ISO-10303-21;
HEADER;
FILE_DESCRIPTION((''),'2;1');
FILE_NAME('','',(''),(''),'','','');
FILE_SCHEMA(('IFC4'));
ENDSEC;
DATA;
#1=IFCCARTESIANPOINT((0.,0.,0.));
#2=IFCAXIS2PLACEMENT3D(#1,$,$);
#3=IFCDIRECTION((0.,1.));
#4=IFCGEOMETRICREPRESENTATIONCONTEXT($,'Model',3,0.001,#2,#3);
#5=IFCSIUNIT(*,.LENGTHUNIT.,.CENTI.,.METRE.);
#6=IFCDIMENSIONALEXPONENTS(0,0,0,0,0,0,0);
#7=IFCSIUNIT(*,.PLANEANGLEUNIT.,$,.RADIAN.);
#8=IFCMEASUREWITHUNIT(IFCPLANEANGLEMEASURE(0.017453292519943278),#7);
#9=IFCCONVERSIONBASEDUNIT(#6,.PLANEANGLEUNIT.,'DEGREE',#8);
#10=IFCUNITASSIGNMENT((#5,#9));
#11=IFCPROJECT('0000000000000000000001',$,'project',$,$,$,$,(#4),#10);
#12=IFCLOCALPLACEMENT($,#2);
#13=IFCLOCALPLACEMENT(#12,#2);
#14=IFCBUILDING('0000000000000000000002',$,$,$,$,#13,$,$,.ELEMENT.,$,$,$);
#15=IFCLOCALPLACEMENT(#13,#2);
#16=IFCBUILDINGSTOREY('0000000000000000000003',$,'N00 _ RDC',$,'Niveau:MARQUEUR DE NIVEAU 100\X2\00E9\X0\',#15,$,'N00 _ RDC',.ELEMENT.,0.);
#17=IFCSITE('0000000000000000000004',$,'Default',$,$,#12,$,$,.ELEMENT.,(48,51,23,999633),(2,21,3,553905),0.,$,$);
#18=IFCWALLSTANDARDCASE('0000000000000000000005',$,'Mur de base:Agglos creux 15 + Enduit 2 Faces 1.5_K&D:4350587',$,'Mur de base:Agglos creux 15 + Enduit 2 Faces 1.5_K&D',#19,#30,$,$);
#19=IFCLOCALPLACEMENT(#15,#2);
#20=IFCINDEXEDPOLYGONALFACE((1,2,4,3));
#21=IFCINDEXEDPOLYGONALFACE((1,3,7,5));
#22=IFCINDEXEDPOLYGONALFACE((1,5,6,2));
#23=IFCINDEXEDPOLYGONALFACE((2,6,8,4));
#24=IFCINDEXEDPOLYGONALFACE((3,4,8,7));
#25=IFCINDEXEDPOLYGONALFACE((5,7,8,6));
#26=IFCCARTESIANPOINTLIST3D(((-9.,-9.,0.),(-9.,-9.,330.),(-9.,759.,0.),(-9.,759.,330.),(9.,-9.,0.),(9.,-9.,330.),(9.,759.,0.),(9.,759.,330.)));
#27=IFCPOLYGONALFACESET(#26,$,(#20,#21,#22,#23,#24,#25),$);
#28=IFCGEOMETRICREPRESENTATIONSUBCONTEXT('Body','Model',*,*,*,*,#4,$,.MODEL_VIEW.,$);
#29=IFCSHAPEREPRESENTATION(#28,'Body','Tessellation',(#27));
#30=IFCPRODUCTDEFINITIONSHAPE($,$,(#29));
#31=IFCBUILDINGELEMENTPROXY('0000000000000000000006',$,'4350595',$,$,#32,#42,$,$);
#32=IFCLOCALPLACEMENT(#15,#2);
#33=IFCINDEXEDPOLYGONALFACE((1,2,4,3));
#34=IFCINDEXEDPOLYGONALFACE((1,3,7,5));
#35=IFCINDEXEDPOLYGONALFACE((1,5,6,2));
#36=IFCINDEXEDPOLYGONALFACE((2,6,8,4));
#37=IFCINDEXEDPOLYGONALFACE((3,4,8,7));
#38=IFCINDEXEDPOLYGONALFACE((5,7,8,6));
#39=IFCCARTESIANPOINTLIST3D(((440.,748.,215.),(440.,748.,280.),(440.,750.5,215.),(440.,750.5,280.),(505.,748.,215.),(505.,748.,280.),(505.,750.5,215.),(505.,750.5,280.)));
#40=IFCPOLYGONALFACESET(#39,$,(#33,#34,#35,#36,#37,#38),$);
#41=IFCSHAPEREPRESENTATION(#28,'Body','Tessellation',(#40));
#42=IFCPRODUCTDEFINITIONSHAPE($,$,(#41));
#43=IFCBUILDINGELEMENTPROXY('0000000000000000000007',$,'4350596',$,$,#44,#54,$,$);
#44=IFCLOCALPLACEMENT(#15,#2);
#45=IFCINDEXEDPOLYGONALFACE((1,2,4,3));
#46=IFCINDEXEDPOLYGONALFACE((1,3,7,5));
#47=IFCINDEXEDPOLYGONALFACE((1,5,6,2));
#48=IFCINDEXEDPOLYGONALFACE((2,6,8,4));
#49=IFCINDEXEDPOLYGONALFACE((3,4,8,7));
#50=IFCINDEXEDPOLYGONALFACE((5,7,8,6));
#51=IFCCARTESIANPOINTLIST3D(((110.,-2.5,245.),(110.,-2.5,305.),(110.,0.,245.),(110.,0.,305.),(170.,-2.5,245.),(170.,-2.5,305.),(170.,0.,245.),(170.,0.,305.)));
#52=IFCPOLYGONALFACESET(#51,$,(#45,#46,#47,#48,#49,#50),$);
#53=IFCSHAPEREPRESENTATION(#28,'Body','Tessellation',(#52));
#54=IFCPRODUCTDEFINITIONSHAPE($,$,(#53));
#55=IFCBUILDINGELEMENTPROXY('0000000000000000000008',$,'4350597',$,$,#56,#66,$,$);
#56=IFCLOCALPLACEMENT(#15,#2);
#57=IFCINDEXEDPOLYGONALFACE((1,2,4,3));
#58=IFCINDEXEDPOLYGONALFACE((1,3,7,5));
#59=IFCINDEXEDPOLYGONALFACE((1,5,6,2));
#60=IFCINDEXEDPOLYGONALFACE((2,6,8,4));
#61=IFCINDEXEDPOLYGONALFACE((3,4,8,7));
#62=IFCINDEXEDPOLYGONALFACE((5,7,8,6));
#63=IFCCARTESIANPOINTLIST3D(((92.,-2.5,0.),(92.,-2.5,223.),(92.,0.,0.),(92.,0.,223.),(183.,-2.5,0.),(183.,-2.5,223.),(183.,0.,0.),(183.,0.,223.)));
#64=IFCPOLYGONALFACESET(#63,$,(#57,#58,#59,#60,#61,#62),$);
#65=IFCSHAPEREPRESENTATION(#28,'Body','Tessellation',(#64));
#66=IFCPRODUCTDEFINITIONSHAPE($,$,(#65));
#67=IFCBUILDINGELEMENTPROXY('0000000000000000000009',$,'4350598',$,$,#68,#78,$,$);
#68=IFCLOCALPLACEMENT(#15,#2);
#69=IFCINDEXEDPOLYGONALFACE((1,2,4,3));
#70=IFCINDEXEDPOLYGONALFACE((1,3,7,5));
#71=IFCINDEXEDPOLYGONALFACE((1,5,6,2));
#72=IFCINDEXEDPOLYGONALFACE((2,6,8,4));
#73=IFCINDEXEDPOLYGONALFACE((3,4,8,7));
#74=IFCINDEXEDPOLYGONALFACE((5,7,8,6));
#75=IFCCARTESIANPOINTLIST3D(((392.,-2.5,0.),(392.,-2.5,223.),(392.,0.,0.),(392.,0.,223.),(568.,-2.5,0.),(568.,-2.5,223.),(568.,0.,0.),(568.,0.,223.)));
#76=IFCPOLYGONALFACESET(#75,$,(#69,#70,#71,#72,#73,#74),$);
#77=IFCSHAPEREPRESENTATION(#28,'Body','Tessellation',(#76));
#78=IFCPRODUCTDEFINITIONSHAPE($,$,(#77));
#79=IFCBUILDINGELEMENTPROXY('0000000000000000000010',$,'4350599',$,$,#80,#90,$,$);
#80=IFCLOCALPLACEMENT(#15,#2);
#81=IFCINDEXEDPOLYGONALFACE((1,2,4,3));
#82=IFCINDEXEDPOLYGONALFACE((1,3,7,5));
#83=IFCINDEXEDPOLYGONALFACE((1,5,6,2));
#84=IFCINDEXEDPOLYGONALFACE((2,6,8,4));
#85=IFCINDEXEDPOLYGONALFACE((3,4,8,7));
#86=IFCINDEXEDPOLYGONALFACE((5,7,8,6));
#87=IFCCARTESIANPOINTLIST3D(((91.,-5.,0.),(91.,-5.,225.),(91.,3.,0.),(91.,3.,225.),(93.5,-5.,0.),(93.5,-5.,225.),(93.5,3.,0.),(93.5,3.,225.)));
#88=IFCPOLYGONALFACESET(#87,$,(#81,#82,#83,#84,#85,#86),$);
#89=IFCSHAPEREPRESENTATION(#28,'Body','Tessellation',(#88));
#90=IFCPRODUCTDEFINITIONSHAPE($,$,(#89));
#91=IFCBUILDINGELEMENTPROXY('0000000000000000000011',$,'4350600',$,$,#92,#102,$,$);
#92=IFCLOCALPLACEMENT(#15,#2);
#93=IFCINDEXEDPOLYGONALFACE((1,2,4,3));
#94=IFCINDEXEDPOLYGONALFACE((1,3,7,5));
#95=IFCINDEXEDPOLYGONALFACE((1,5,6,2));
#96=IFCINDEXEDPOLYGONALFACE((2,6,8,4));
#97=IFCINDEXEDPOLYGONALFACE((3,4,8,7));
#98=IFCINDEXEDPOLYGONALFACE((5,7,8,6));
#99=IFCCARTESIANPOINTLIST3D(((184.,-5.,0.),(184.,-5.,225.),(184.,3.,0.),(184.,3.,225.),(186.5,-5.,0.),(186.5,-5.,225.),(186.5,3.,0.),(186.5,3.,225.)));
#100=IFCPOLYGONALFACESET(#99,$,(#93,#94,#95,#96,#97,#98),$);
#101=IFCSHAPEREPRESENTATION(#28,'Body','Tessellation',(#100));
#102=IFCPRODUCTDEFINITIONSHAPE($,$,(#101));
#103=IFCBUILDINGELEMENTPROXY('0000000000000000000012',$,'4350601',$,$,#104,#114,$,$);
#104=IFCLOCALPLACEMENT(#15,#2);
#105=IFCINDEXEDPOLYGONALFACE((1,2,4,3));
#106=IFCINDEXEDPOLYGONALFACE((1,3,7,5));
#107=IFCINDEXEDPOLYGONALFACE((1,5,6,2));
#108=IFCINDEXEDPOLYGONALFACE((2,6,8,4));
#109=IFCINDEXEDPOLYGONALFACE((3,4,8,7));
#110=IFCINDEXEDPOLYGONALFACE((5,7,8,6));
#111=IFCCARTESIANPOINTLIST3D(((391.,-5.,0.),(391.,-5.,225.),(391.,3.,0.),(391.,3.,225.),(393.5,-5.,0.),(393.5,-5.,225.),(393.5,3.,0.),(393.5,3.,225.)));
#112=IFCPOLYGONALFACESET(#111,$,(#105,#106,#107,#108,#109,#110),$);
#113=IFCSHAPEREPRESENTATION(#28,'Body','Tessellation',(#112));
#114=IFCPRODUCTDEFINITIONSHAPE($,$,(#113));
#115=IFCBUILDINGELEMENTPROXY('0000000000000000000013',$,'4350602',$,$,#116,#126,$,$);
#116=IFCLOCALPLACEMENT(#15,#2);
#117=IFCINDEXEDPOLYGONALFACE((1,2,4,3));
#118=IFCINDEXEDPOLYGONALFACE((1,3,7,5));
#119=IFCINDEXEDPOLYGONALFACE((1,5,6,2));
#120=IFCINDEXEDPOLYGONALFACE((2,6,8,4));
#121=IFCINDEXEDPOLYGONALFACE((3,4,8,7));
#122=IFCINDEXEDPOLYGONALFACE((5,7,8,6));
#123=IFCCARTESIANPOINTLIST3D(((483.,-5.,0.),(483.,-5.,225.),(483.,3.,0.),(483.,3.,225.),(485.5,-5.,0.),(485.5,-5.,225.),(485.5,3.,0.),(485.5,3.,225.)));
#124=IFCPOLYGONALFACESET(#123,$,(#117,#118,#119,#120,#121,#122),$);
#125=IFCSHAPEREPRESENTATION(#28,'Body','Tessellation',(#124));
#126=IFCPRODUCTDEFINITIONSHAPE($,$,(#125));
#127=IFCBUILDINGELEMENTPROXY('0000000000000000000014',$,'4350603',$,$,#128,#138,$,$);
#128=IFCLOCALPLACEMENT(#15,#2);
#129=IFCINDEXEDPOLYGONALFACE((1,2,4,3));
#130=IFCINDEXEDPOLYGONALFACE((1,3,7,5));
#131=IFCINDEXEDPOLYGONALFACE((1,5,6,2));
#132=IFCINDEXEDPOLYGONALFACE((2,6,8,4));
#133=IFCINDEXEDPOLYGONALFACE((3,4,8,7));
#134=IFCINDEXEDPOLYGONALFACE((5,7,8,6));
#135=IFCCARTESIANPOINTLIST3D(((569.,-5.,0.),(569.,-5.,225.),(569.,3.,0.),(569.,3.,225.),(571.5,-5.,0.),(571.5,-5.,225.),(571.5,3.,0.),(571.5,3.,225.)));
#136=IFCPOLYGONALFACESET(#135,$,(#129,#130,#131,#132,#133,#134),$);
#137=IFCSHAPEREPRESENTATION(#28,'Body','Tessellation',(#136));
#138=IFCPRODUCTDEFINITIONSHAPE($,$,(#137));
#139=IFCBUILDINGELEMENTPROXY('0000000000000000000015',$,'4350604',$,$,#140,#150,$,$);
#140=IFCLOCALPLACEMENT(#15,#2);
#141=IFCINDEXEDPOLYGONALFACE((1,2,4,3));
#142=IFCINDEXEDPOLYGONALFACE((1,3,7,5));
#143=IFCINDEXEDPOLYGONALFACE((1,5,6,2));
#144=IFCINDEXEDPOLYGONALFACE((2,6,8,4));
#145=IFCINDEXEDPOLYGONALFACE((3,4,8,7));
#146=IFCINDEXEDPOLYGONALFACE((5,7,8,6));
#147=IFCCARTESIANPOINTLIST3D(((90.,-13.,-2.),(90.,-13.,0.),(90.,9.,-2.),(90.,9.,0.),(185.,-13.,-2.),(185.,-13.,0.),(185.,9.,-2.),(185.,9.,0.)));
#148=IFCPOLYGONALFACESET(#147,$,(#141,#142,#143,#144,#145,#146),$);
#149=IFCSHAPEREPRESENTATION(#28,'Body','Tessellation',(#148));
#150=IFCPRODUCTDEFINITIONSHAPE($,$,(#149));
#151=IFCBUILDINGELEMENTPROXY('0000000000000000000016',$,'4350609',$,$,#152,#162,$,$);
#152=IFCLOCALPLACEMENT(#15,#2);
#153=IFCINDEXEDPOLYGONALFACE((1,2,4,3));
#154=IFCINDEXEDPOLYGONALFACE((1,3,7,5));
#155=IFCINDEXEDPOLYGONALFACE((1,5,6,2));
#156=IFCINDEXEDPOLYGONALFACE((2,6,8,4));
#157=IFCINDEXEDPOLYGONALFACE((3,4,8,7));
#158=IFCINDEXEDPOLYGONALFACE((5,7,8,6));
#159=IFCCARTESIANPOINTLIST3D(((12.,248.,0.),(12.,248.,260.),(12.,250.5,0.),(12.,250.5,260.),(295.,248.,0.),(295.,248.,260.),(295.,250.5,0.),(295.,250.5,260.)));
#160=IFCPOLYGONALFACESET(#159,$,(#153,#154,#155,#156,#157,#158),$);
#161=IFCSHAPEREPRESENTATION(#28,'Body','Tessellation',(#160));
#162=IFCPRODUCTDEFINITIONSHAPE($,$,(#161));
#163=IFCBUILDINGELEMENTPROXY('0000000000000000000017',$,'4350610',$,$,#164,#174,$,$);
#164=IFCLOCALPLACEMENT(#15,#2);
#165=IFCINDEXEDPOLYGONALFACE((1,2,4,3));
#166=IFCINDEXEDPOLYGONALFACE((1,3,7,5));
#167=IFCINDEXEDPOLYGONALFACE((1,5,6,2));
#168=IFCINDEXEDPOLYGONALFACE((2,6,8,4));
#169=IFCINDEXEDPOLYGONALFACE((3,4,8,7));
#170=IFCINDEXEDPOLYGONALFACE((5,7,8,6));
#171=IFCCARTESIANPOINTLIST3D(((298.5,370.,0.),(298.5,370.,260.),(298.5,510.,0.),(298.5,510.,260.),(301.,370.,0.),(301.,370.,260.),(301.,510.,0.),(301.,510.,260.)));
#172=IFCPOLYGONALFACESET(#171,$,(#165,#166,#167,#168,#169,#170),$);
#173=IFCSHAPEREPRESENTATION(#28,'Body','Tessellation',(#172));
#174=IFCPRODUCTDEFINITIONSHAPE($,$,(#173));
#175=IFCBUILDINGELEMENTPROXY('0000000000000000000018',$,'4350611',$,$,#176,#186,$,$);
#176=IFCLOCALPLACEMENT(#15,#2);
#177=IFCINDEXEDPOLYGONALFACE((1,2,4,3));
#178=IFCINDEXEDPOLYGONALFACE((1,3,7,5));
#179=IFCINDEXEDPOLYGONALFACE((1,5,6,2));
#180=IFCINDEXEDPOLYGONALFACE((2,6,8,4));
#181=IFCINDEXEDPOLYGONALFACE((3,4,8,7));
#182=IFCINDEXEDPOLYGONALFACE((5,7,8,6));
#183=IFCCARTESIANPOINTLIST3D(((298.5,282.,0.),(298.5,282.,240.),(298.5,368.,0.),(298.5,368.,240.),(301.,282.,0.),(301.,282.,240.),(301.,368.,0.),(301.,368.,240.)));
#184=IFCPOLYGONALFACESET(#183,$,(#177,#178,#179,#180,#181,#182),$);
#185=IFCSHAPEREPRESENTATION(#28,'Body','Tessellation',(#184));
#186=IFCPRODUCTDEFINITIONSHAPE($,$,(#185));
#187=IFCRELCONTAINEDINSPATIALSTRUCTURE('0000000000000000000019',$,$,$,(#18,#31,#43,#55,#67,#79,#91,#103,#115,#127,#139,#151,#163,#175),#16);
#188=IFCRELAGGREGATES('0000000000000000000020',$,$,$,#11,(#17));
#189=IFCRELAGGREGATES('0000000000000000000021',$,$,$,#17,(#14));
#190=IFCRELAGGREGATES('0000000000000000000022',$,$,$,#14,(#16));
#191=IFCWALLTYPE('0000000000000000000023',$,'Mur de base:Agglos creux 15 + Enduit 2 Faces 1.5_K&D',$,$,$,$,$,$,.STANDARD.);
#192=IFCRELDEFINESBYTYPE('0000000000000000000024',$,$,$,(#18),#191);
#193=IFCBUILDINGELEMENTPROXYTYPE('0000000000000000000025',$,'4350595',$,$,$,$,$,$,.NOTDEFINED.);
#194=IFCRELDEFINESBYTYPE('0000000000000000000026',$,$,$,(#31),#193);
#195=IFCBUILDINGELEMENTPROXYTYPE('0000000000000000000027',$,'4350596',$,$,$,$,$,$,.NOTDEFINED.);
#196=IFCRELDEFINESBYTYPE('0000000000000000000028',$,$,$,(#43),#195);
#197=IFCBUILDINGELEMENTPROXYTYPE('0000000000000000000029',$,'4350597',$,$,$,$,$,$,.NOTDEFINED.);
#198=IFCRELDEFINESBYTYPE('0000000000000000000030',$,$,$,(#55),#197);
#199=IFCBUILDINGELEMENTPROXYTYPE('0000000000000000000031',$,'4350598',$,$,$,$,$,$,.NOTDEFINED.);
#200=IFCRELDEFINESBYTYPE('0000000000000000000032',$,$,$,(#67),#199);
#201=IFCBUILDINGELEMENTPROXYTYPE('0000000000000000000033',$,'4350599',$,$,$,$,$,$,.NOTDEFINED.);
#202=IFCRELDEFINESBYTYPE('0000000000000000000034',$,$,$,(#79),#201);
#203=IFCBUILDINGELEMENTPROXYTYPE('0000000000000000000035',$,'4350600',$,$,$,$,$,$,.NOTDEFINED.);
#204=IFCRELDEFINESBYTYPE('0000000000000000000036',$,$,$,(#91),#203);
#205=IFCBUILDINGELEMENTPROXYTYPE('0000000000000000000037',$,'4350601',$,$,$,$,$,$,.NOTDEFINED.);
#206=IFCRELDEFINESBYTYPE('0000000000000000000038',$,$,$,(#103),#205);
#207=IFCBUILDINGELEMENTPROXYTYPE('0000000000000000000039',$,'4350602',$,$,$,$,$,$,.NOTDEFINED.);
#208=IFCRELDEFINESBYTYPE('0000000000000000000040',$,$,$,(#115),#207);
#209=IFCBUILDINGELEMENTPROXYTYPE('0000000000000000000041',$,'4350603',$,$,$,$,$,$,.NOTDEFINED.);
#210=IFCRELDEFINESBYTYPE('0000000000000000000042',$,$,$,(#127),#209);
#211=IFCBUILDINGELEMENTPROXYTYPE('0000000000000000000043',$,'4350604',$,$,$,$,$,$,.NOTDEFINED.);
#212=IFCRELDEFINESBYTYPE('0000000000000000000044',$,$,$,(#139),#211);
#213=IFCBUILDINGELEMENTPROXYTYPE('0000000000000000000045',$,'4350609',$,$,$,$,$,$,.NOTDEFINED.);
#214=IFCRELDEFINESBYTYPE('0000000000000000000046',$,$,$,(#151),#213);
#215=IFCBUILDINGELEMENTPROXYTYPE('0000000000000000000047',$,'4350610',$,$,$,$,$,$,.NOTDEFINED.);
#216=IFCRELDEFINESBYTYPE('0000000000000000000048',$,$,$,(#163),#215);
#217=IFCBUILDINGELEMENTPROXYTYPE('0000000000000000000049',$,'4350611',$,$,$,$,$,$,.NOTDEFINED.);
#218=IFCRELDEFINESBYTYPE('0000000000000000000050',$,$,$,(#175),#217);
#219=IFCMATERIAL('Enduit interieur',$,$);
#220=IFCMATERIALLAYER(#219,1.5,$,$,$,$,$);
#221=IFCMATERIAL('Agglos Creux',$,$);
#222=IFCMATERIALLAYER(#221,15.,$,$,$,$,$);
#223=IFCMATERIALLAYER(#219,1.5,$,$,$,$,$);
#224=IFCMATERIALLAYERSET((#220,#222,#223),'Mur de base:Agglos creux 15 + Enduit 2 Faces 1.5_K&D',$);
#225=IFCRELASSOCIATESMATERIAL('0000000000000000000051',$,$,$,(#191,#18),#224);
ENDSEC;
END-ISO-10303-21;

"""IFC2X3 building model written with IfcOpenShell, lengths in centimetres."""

from ifc_helpers import new_model, entity, si_unit, converted_unit, direction, frame, frame_2d, origin, origin_2d_with_axis, place, context, subcontext, project, spatial, rectangle, extrude, material, layer, layer_set, layer_usage, type_object, element, save


model = new_model("IFC2X3")

# Units and contexts
model_context = context("Model", 3, precision=0.001, world=origin(), true_north=direction((0.0, 1.0)))
body_context = subcontext(model_context, "Body", "Model", "MODEL_VIEW")
ifc_project = project(units=[si_unit("LENGTHUNIT", "METRE", prefix="CENTI"), converted_unit("PLANEANGLEUNIT", "DEGREE", entity("IfcPlaneAngleMeasure", 0.017453292519943278), si_unit("PLANEANGLEUNIT", "RADIAN"), dimensions=[0, 0, 0, 0, 0, 0, 0])], contexts=[model_context])

# Site, building, storey
site_placement = place(None, origin())
site = spatial("IfcSite", under=ifc_project, at=site_placement, Name="Default", CompositionType="ELEMENT", RefLatitude=(48, 51, 23, 999633), RefLongitude=(2, 21, 3, 553905), RefElevation=0.0)
building_placement = place(site_placement, origin())
building = spatial("IfcBuilding", under=site, at=building_placement, CompositionType="ELEMENT")
storey_placement = place(building_placement, origin())
storey = spatial("IfcBuildingStorey", under=building, at=storey_placement, Name="N00 _ RDC", ObjectType="Niveau:MARQUEUR DE NIVEAU 100é", LongName="N00 _ RDC", CompositionType="ELEMENT", Elevation=0.0)

# Wall
ifc_material_1 = material(Name="Enduit interieur")
ifc_layer_1 = layer(ifc_material_1, 1.5)
ifc_material_2 = material(Name="Agglos Creux")
ifc_layer_2 = layer(ifc_material_2, 15.0)
ifc_layer_3 = layer(ifc_material_1, 1.5)
ifc_layer_set = layer_set([ifc_layer_1, ifc_layer_2, ifc_layer_3], Name="Mur de base:Agglos creux 15 + Enduit 2 Faces 1.5_K&D")
ifc_layer_usage = layer_usage(ifc_layer_set, "AXIS2", "NEGATIVE", 9.0)
wall_type = type_object("IfcWallType", Name="Mur de base:Agglos creux 15 + Enduit 2 Faces 1.5_K&D", PredefinedType="STANDARD", material=ifc_layer_set)
wall_placement = place(storey_placement, frame((0.0, -9.0, 0.0), z_axis=(0.0, 0.0, 1.0), x_axis=(0.0, 1.0, 0.0)))
element("IfcWallStandardCase", 1, at=wall_placement, inside=storey, type_object=wall_type, material=ifc_layer_usage, Name="Mur de base:Agglos creux 15 + Enduit 2 Faces 1.5_K&D:4350587", ObjectType="Mur de base:Agglos creux 15 + Enduit 2 Faces 1.5_K&D", context=body_context, shape_type="SweptSolid", body=[
    extrude(rectangle(XDim=768.0, YDim=18.0, at=frame_2d((384.0, 0.0), x_axis=(-1.0, 0.0))), origin(), (0.0, 0.0, 1.0), 330.0),
])

# Building element proxies
building_element_proxy_type_1 = type_object("IfcBuildingElementProxyType", Name="4350595", PredefinedType="NOTDEFINED")
proxy_1_placement = place(storey_placement, origin())
element("IfcBuildingElementProxy", 2, at=proxy_1_placement, inside=storey, type_object=building_element_proxy_type_1, Name="4350595", context=body_context, shape_type="SweptSolid", body=[
    extrude(rectangle(XDim=65.0, YDim=2.5, at=frame_2d((0.0, 0.0), x_axis=(1.0, 0.0))), frame((472.5, 749.25, 215.0)), (0.0, 0.0, 1.0), 65.0),
])
building_element_proxy_type_2 = type_object("IfcBuildingElementProxyType", Name="4350596", PredefinedType="NOTDEFINED")
proxy_2_placement = place(storey_placement, origin())
element("IfcBuildingElementProxy", 3, at=proxy_2_placement, inside=storey, type_object=building_element_proxy_type_2, Name="4350596", context=body_context, shape_type="SweptSolid", body=[
    extrude(rectangle(XDim=60.0, YDim=2.5, at=origin_2d_with_axis()), frame((140.0, -1.25, 245.0)), (0.0, 0.0, 1.0), 60.0),
])
building_element_proxy_type_3 = type_object("IfcBuildingElementProxyType", Name="4350597", PredefinedType="NOTDEFINED")
proxy_3_placement = place(storey_placement, origin())
element("IfcBuildingElementProxy", 4, at=proxy_3_placement, inside=storey, type_object=building_element_proxy_type_3, Name="4350597", context=body_context, shape_type="SweptSolid", body=[
    extrude(rectangle(XDim=91.0, YDim=2.5, at=frame_2d((0.0, 0.0), x_axis=(1.0, 0.0))), frame((137.5, -1.25, 0.0)), (0.0, 0.0, 1.0), 223.0),
])
building_element_proxy_type_4 = type_object("IfcBuildingElementProxyType", Name="4350598", PredefinedType="NOTDEFINED")
proxy_4_placement = place(storey_placement, origin())
element("IfcBuildingElementProxy", 5, at=proxy_4_placement, inside=storey, type_object=building_element_proxy_type_4, Name="4350598", context=body_context, shape_type="SweptSolid", body=[
    extrude(rectangle(XDim=176.0, YDim=2.5, at=frame_2d((0.0, 0.0), x_axis=(1.0, 0.0))), frame((480.0, -1.25, 0.0)), (0.0, 0.0, 1.0), 223.0),
])
building_element_proxy_type_5 = type_object("IfcBuildingElementProxyType", Name="4350599", PredefinedType="NOTDEFINED")
proxy_5_placement = place(storey_placement, origin())
element("IfcBuildingElementProxy", 6, at=proxy_5_placement, inside=storey, type_object=building_element_proxy_type_5, Name="4350599", context=body_context, shape_type="SweptSolid", body=[
    extrude(rectangle(XDim=2.5, YDim=8.0, at=frame_2d((0.0, 0.0), x_axis=(1.0, 0.0))), frame((92.25, -1.0, 0.0)), (0.0, 0.0, 1.0), 225.0),
])
building_element_proxy_type_6 = type_object("IfcBuildingElementProxyType", Name="4350600", PredefinedType="NOTDEFINED")
proxy_6_placement = place(storey_placement, origin())
element("IfcBuildingElementProxy", 7, at=proxy_6_placement, inside=storey, type_object=building_element_proxy_type_6, Name="4350600", context=body_context, shape_type="SweptSolid", body=[
    extrude(rectangle(XDim=2.5, YDim=8.0, at=frame_2d((0.0, 0.0), x_axis=(1.0, 0.0))), frame((185.25, -1.0, 0.0)), (0.0, 0.0, 1.0), 225.0),
])
building_element_proxy_type_7 = type_object("IfcBuildingElementProxyType", Name="4350601", PredefinedType="NOTDEFINED")
proxy_7_placement = place(storey_placement, origin())
element("IfcBuildingElementProxy", 8, at=proxy_7_placement, inside=storey, type_object=building_element_proxy_type_7, Name="4350601", context=body_context, shape_type="SweptSolid", body=[
    extrude(rectangle(XDim=2.5, YDim=8.0, at=frame_2d((0.0, 0.0), x_axis=(1.0, 0.0))), frame((392.25, -1.0, 0.0)), (0.0, 0.0, 1.0), 225.0),
])
building_element_proxy_type_8 = type_object("IfcBuildingElementProxyType", Name="4350602", PredefinedType="NOTDEFINED")
proxy_8_placement = place(storey_placement, origin())
element("IfcBuildingElementProxy", 9, at=proxy_8_placement, inside=storey, type_object=building_element_proxy_type_8, Name="4350602", context=body_context, shape_type="SweptSolid", body=[
    extrude(rectangle(XDim=2.5, YDim=8.0, at=frame_2d((0.0, 0.0), x_axis=(1.0, 0.0))), frame((484.25, -1.0, 0.0)), (0.0, 0.0, 1.0), 225.0),
])
building_element_proxy_type_9 = type_object("IfcBuildingElementProxyType", Name="4350603", PredefinedType="NOTDEFINED")
proxy_9_placement = place(storey_placement, origin())
element("IfcBuildingElementProxy", 10, at=proxy_9_placement, inside=storey, type_object=building_element_proxy_type_9, Name="4350603", context=body_context, shape_type="SweptSolid", body=[
    extrude(rectangle(XDim=2.5, YDim=8.0, at=frame_2d((0.0, 0.0), x_axis=(1.0, 0.0))), frame((570.25, -1.0, 0.0)), (0.0, 0.0, 1.0), 225.0),
])
building_element_proxy_type_10 = type_object("IfcBuildingElementProxyType", Name="4350604", PredefinedType="NOTDEFINED")
proxy_10_placement = place(storey_placement, origin())
element("IfcBuildingElementProxy", 11, at=proxy_10_placement, inside=storey, type_object=building_element_proxy_type_10, Name="4350604", context=body_context, shape_type="SweptSolid", body=[
    extrude(rectangle(XDim=95.0, YDim=22.0, at=origin_2d_with_axis()), frame((137.5, -2.0, -2.0)), (0.0, 0.0, 1.0), 2.0),
])
building_element_proxy_type_11 = type_object("IfcBuildingElementProxyType", Name="4350609", PredefinedType="NOTDEFINED")
proxy_11_placement = place(storey_placement, origin())
element("IfcBuildingElementProxy", 12, at=proxy_11_placement, inside=storey, type_object=building_element_proxy_type_11, Name="4350609", context=body_context, shape_type="SweptSolid", body=[
    extrude(rectangle(XDim=283.0, YDim=2.5, at=frame_2d((0.0, 0.0), x_axis=(1.0, 0.0))), frame((153.5, 249.25, 0.0)), (0.0, 0.0, 1.0), 260.0),
])
building_element_proxy_type_12 = type_object("IfcBuildingElementProxyType", Name="4350610", PredefinedType="NOTDEFINED")
proxy_12_placement = place(storey_placement, origin())
element("IfcBuildingElementProxy", 13, at=proxy_12_placement, inside=storey, type_object=building_element_proxy_type_12, Name="4350610", context=body_context, shape_type="SweptSolid", body=[
    extrude(rectangle(XDim=2.5, YDim=140.0, at=origin_2d_with_axis()), frame((299.75, 440.0, 0.0)), (0.0, 0.0, 1.0), 260.0),
])
building_element_proxy_type_13 = type_object("IfcBuildingElementProxyType", Name="4350611", PredefinedType="NOTDEFINED")
proxy_13_placement = place(storey_placement, origin())
element("IfcBuildingElementProxy", 14, at=proxy_13_placement, inside=storey, type_object=building_element_proxy_type_13, Name="4350611", context=body_context, shape_type="SweptSolid", body=[
    extrude(rectangle(XDim=2.5, YDim=86.0, at=frame_2d((0.0, 0.0), x_axis=(1.0, 0.0))), frame((299.75, 325.0, 0.0)), (0.0, 0.0, 1.0), 240.0),
])

save(model, "model.ifc")
